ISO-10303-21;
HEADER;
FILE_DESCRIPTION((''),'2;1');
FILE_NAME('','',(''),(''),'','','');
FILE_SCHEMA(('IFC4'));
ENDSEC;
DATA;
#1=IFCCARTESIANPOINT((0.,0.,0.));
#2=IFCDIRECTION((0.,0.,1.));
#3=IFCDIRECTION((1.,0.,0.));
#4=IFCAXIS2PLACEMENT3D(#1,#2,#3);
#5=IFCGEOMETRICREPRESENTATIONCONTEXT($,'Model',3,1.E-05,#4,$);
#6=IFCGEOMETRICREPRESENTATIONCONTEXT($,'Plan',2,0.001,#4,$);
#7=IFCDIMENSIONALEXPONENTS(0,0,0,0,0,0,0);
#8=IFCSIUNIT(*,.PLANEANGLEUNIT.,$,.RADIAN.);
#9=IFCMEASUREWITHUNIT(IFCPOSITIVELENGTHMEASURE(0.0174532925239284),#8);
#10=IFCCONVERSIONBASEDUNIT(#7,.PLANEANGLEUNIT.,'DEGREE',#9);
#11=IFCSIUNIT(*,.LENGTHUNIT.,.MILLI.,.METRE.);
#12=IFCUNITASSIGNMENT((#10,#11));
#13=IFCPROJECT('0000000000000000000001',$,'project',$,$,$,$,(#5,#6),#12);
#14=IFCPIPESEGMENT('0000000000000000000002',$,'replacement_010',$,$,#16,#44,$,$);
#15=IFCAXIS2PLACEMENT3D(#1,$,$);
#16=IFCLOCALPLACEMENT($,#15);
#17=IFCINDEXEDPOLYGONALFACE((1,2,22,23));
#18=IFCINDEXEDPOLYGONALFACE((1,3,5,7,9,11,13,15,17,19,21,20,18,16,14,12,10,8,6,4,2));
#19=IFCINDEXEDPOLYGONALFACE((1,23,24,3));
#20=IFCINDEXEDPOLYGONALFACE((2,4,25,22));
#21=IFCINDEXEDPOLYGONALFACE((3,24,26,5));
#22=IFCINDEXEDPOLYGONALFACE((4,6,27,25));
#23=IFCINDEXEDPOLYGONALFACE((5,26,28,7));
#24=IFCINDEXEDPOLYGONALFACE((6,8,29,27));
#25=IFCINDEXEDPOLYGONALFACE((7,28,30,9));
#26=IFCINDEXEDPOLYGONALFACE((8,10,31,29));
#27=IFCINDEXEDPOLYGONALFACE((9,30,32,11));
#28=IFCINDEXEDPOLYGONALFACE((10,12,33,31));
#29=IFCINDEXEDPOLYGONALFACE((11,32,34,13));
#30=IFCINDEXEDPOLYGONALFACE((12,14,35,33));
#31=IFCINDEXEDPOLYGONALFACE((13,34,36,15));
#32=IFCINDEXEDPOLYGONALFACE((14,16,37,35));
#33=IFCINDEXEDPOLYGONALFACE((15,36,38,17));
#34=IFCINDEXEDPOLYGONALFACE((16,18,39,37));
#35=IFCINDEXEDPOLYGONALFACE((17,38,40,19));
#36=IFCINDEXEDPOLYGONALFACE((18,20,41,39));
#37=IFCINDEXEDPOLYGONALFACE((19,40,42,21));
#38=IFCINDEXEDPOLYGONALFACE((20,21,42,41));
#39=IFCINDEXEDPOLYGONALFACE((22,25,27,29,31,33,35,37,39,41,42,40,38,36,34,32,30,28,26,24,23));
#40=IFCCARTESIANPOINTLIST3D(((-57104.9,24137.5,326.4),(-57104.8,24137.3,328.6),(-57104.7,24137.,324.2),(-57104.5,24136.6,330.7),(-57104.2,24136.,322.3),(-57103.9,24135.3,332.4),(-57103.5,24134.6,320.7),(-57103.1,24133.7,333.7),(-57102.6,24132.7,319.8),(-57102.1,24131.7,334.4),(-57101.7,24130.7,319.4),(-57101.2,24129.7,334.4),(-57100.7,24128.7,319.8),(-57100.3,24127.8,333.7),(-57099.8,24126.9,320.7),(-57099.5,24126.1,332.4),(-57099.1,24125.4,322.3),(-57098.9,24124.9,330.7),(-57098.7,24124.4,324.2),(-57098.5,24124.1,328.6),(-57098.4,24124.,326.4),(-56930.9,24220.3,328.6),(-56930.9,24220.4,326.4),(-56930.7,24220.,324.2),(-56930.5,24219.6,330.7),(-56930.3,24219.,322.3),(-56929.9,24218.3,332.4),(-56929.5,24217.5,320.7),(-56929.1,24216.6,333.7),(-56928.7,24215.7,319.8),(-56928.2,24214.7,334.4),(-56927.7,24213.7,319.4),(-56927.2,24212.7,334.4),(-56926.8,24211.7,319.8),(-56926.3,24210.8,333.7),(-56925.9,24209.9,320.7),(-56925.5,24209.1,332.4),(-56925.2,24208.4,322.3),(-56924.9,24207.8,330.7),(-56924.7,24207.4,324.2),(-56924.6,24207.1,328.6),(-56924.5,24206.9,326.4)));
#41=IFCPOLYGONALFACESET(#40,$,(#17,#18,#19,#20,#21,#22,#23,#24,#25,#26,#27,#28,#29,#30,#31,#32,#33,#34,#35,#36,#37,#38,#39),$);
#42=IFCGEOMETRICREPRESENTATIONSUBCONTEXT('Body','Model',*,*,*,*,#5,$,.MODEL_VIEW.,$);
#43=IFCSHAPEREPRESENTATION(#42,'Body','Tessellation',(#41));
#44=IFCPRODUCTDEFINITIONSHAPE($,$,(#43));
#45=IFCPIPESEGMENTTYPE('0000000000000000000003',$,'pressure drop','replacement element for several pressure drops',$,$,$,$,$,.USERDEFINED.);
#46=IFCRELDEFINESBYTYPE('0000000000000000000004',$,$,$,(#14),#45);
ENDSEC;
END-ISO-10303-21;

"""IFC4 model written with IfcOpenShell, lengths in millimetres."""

from ifc_helpers import new_model, entity, si_unit, converted_unit, frame, frame_2d, origin, origin_with_axes, place, context, subcontext, project, circle, extrude, source, transform, mapped, type_object, element, save


model = new_model("IFC4")

# Units and contexts
model_context = context("Model", 3, precision=1e-05, world=origin_with_axes())
plan_context = context("Plan", 2, precision=0.001, world=origin_with_axes())
body_context = subcontext(model_context, "Body", "Model", "MODEL_VIEW")
ifc_project = project(units=[converted_unit("PLANEANGLEUNIT", "DEGREE", entity("IfcPositiveLengthMeasure", 0.0174532925239284), si_unit("PLANEANGLEUNIT", "RADIAN"), dimensions=[0, 0, 0, 0, 0, 0, 0]), si_unit("LENGTHUNIT", "METRE", prefix="MILLI")], contexts=[model_context, plan_context])

# Pipe segment
shared_shape = source(origin(), body_context, "Body", "SweptSolid", [
    extrude(circle(Radius=7.5, at=frame_2d((7.5, 7.5), x_axis=(1.0, 0.0))), frame((0.0, -7.5, -7.5), z_axis=(1.0, 0.0, 0.0), x_axis=(0.0, 1.0, 0.0)), (0.0, 0.0, 1.0), 1.0),
])
placement_1 = place(None, origin_with_axes())
placement_2 = place(placement_1, origin_with_axes())
placement_3 = place(placement_2, frame((0.0, 0.0, -3400.0), z_axis=(0.0, 0.0, 1.0), x_axis=(1.0, 0.0, 0.0)))
pipe_segment_type_1 = type_object("IfcPipeSegmentType", Name="pressure drop", Description="replacement element for several pressure drops", PredefinedType="USERDEFINED")
for number, where, z_axis, x_axis, name in (
    (1, (-57101.7, 24130.7, 3726.9), (-0.430461, 0.902609, 0.0), (0.902609, 0.430461, 0.0), "replacement_010"),
):
    element("IfcPipeSegment", number, at=place(placement_3, frame(where, z_axis=z_axis, x_axis=x_axis)), type_object=pipe_segment_type_1, Name=name, context=body_context, shape_type="MappedRepresentation", body=[
        mapped(shared_shape, transform((0.0, 0.0, 0.0), x_axis=(1.0, 0.0, 0.0), y_axis=(0.0, 1.0, 0.0), z_axis=(0.0, 0.0, 1.0), scale=192.697716, scale2=1.0, scale3=1.0, uniform=False)),
    ])

save(model, "model.ifc")
